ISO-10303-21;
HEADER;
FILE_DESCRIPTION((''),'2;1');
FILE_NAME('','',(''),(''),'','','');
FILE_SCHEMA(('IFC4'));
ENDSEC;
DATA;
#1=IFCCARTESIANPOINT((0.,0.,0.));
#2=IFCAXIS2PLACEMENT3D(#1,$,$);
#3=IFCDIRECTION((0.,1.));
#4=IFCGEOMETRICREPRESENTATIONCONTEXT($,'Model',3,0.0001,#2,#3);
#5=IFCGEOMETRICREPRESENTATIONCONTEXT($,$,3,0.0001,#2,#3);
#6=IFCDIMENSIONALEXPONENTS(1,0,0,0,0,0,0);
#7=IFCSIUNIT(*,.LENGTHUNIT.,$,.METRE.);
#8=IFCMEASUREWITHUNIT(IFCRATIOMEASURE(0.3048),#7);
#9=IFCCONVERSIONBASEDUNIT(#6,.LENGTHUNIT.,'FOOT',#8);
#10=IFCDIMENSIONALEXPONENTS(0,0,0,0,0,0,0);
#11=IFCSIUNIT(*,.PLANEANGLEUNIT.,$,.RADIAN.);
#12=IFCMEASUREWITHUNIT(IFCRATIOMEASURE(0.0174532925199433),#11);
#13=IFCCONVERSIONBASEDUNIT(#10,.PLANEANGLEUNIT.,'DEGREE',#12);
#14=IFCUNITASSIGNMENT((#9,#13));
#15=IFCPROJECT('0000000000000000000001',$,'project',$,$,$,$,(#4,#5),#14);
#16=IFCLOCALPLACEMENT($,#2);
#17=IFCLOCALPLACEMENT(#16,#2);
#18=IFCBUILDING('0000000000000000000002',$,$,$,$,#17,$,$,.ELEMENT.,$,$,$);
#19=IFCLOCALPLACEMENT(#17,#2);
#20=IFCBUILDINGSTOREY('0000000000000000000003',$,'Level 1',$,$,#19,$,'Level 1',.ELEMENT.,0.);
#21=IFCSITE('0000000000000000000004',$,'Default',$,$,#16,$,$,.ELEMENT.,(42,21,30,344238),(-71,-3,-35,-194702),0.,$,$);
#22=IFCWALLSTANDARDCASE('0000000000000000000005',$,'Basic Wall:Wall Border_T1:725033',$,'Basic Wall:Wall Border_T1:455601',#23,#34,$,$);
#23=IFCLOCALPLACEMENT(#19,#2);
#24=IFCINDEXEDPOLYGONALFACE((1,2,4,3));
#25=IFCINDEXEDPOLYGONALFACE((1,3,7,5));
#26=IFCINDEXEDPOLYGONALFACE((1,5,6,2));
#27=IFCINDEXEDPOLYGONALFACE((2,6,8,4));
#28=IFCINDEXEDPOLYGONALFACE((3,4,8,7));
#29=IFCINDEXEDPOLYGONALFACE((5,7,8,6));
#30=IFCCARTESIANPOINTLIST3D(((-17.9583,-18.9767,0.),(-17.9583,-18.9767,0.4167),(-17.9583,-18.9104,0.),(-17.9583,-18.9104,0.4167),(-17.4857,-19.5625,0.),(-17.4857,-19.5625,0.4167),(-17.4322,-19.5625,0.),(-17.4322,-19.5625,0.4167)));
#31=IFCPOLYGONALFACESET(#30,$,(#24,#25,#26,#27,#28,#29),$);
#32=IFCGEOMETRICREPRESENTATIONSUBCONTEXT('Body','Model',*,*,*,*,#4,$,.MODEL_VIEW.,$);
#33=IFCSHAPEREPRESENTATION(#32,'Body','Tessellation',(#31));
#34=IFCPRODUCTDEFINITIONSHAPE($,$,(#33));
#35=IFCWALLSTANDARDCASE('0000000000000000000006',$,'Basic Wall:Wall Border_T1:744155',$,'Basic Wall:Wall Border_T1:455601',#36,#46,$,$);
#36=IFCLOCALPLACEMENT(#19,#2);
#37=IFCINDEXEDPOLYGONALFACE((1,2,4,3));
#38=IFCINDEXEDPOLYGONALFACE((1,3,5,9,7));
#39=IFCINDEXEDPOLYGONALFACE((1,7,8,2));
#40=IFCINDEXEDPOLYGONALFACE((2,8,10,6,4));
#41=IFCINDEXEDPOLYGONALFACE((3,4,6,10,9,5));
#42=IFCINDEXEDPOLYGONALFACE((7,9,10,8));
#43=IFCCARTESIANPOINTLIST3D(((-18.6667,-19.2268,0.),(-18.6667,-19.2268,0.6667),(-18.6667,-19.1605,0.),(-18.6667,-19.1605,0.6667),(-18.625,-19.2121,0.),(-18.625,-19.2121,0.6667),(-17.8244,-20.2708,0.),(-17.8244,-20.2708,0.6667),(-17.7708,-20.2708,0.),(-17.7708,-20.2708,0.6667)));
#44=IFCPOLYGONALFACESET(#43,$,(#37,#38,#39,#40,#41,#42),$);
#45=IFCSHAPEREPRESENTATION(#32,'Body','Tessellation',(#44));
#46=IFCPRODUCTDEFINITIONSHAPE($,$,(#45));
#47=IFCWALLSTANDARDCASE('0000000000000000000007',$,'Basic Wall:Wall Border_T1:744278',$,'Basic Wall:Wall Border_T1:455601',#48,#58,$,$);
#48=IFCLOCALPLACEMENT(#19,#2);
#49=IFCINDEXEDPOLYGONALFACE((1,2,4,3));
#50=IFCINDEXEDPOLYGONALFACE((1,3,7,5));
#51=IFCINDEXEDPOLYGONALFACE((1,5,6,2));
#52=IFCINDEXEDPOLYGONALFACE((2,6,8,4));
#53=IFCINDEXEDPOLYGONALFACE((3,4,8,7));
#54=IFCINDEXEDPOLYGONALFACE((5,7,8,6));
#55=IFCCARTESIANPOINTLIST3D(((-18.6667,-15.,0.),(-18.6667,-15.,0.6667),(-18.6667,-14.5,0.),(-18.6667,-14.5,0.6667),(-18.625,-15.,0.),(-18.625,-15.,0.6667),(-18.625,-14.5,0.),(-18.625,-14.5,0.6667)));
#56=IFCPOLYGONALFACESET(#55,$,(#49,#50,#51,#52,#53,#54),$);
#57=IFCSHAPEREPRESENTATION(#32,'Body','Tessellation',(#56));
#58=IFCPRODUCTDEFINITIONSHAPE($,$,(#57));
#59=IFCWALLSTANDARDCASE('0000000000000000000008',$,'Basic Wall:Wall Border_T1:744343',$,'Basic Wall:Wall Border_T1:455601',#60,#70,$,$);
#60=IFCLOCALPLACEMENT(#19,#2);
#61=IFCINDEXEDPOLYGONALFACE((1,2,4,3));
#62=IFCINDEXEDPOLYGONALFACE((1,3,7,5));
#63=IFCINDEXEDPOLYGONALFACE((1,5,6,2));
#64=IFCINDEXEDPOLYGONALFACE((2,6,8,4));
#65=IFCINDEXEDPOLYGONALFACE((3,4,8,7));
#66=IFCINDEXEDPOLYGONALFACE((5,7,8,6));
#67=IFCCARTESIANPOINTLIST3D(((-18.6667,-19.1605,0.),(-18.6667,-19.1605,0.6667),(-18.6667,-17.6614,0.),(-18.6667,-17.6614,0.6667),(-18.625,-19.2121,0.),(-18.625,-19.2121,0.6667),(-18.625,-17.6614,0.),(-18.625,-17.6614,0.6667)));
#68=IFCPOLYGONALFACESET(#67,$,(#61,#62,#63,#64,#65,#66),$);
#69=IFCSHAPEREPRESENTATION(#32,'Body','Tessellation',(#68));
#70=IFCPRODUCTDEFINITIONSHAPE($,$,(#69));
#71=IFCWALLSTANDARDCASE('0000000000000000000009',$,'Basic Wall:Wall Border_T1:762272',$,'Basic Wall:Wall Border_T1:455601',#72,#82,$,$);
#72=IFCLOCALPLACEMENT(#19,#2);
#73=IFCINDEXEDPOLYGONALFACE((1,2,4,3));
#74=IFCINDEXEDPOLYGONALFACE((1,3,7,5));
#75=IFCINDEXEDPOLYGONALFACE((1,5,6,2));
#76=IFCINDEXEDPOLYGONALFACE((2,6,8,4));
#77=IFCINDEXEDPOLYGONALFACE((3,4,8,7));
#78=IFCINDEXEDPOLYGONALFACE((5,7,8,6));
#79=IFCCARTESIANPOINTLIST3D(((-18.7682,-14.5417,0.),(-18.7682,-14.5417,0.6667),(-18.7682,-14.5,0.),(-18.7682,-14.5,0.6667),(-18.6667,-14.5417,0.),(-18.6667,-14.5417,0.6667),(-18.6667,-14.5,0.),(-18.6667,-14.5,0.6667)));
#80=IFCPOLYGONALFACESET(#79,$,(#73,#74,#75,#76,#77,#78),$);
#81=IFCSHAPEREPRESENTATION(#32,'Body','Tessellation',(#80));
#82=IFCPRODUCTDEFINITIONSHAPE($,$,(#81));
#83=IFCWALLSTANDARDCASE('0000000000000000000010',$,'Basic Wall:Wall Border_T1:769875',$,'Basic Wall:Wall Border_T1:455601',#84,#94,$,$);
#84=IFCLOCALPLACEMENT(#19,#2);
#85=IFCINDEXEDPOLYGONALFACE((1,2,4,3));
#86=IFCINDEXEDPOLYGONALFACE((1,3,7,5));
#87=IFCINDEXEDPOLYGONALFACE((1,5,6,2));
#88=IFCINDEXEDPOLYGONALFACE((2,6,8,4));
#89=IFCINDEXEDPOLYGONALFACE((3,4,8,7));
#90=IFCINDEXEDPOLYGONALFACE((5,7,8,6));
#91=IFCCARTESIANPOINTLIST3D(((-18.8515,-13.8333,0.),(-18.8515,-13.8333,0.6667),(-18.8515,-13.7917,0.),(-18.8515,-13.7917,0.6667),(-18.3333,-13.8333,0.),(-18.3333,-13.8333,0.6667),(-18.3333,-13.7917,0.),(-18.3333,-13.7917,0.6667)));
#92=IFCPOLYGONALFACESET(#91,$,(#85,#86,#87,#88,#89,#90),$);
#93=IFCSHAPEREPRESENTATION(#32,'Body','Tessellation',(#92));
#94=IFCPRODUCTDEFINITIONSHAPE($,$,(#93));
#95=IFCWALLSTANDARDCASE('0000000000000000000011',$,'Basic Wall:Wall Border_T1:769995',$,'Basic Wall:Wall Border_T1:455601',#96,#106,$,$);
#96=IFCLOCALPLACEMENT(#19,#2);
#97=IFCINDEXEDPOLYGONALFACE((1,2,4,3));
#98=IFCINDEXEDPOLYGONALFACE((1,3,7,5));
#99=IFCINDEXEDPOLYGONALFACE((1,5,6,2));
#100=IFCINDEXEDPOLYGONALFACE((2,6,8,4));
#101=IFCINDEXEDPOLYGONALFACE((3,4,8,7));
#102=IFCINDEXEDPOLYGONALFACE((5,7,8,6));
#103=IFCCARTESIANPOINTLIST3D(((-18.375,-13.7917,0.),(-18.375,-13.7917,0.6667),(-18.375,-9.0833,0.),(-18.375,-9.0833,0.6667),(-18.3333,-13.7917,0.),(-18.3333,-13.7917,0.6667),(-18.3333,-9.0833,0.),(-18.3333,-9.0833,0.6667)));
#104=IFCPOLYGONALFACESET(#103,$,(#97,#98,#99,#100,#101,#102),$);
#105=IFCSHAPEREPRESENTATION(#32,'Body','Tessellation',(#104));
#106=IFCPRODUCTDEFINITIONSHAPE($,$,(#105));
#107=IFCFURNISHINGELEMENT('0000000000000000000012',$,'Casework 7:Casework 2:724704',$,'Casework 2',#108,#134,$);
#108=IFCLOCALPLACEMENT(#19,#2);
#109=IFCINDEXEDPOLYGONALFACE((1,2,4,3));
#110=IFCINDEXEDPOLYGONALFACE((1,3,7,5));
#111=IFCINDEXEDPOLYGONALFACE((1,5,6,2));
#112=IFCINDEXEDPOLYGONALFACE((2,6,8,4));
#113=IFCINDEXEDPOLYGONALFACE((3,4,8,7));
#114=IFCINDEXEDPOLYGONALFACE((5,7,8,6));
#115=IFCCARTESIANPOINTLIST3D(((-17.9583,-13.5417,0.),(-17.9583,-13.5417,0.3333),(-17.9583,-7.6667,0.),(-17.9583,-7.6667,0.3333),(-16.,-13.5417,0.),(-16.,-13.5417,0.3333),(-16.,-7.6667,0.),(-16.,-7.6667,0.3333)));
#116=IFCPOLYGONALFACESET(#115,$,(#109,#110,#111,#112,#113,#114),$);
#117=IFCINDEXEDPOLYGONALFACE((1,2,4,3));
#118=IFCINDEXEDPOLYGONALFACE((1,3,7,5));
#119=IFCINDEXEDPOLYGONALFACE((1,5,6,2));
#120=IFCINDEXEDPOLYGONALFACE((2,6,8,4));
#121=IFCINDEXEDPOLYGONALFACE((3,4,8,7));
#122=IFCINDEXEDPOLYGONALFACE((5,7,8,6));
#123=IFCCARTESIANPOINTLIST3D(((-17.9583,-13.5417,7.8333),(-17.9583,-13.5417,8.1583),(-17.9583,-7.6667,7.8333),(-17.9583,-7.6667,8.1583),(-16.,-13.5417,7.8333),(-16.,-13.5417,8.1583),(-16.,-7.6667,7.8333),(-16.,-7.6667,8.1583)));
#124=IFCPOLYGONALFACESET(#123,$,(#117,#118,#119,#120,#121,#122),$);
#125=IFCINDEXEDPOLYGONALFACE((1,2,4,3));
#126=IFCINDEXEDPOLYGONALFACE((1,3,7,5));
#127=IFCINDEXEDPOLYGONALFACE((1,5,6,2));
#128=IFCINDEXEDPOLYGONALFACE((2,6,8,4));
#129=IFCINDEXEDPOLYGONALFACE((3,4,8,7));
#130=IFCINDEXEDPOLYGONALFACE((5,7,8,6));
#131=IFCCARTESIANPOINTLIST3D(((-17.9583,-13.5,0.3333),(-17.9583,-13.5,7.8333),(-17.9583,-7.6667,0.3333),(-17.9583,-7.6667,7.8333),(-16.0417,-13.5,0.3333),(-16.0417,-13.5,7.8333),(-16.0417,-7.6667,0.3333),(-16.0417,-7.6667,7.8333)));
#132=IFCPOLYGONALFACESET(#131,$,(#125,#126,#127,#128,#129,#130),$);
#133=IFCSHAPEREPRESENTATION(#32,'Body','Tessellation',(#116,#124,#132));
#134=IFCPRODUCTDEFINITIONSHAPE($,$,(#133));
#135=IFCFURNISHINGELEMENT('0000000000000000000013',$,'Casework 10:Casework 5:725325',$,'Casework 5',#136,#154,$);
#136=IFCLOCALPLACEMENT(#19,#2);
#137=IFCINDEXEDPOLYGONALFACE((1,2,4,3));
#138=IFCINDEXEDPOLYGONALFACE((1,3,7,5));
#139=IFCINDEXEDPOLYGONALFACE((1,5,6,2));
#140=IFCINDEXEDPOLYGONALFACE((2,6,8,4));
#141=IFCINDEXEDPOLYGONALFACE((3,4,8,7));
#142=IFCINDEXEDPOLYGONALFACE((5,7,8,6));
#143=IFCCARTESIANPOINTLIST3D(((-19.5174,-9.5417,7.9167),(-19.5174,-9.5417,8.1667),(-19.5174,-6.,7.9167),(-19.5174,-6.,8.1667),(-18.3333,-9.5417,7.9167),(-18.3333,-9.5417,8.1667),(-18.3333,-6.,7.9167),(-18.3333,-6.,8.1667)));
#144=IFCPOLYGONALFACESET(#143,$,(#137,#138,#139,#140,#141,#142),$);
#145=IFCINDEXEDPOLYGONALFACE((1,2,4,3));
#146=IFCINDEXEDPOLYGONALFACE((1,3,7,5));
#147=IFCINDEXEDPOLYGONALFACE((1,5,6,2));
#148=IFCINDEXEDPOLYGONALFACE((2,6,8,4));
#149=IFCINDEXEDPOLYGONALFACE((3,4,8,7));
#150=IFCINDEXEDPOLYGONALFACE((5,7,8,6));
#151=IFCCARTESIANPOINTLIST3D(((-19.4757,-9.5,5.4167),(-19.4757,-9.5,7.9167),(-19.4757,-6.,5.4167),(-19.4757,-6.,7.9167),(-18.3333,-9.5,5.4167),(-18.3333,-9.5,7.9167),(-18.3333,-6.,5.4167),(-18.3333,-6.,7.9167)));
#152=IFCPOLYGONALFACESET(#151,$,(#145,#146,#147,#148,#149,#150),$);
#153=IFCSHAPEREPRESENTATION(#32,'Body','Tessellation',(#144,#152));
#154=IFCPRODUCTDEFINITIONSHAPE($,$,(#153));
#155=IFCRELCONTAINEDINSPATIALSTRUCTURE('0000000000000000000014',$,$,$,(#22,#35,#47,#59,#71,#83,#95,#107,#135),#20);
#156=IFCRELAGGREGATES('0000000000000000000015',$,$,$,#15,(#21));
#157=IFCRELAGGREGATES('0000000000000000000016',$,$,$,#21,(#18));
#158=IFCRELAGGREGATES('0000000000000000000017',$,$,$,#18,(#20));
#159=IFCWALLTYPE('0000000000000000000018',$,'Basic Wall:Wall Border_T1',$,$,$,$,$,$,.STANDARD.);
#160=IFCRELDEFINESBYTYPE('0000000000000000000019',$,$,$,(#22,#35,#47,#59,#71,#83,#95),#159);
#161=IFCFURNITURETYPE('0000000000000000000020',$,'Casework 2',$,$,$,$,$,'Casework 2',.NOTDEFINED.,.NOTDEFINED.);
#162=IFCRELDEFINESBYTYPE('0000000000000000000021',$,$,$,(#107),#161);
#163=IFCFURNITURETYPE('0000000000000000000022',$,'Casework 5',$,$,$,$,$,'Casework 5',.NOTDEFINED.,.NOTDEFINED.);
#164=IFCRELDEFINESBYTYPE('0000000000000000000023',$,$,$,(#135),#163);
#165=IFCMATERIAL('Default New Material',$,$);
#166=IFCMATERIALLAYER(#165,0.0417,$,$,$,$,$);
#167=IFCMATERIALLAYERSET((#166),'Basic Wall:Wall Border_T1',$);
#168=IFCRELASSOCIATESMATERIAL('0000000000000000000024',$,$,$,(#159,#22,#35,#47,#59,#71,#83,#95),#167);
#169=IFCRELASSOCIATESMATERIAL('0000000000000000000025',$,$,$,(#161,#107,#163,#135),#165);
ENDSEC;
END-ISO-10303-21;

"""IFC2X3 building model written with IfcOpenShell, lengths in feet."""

from ifc_helpers import new_model, entity, si_unit, converted_unit, direction, frame, frame_2d, origin, place, context, subcontext, project, spatial, polyline, rectangle, outline, extrude, clip, bounded_halfspace, source, transform, mapped, material, layer, layer_set, layer_usage, type_object, type_shapes, element, save


model = new_model("IFC2X3")

# Units and contexts
model_context = context("Model", 3, precision=0.0001, world=origin(), true_north=direction((0.0, 1.0)))
context_of_model = context(None, 3, precision=0.0001, world=origin(), true_north=direction((0.0, 1.0)))
body_context = subcontext(model_context, "Body", "Model", "MODEL_VIEW")
ifc_project = project(units=[converted_unit("LENGTHUNIT", "FOOT", entity("IfcRatioMeasure", 0.3048), si_unit("LENGTHUNIT", "METRE"), dimensions=[1, 0, 0, 0, 0, 0, 0]), converted_unit("PLANEANGLEUNIT", "DEGREE", entity("IfcRatioMeasure", 0.0174532925199433), si_unit("PLANEANGLEUNIT", "RADIAN"), dimensions=[0, 0, 0, 0, 0, 0, 0])], contexts=[model_context, context_of_model])

# Site, building, storey
site_placement = place(None, origin())
site = spatial("IfcSite", under=ifc_project, at=site_placement, Name="Default", CompositionType="ELEMENT", RefLatitude=(42, 21, 30, 344238), RefLongitude=(-71, -3, -35, -194702), RefElevation=0.0)
building_placement = place(site_placement, origin())
building = spatial("IfcBuilding", under=site, at=building_placement, CompositionType="ELEMENT")
storey_placement = place(building_placement, origin())
storey = spatial("IfcBuildingStorey", under=building, at=storey_placement, Name="Level 1", LongName="Level 1", CompositionType="ELEMENT", Elevation=0.0)

# Shared definitions
ifc_material = material(Name="Default New Material")

# Walls
ifc_layer_1 = layer(ifc_material, 0.0417)
ifc_layer_set_1 = layer_set([ifc_layer_1], Name="Basic Wall:Wall Border_T1")
wall_type_1 = type_object("IfcWallType", Name="Basic Wall:Wall Border_T1", PredefinedType="STANDARD", material=ifc_layer_set_1)
ifc_layer_usage_1 = layer_usage(ifc_layer_set_1, "AXIS2", "NEGATIVE", 0.0208)
wall_1_placement = place(storey_placement, frame((-17.4484, -19.5756, 0.0), z_axis=(0.0, 0.0, 1.0), x_axis=(-0.627919, 0.778278, 0.0)))
element("IfcWallStandardCase", 1, at=wall_1_placement, inside=storey, type_object=wall_type_1, material=ifc_layer_usage_1, Name="Basic Wall:Wall Border_T1:725033", ObjectType="Basic Wall:Wall Border_T1:455601", context=body_context, shape_type="Clipping", body=[
    clip(extrude(outline(polyline([(0.7863, 0.0208), (0.0336, 0.0208), (0.0, -0.0208), (0.7716, -0.0208), (0.8379, -0.0208), (0.7863, 0.0208)])), origin(), (0.0, 0.0, 1.0), 0.4167), bounded_halfspace(frame((0.0, -0.0208, 0.0), z_axis=(0.778278, -0.627919, 0.0), x_axis=(0.627919, 0.778278, 0.0)), True, frame((0.0, -0.0208, 0.0), z_axis=(0.778278, -0.627919, 0.0), x_axis=(0.627919, 0.778278, 0.0)), polyline([(0.0, 0.0), (0.0535, 0.0), (0.0535, 0.4167), (0.0, 0.4167), (0.0, 0.0)]))),
])
ifc_layer_usage_2 = layer_usage(ifc_layer_set_1, "AXIS2", "POSITIVE", -0.0208)
wall_2_placement = place(storey_placement, frame((-18.6829, -19.1736, 0.0), z_axis=(0.0, 0.0, 1.0), x_axis=(0.627919, -0.778278, 0.0)))
element("IfcWallStandardCase", 2, at=wall_2_placement, inside=storey, type_object=wall_type_1, material=ifc_layer_usage_2, Name="Basic Wall:Wall Border_T1:744155", ObjectType="Basic Wall:Wall Border_T1:455601", context=body_context, shape_type="SweptSolid", body=[
    extrude(outline(polyline([(1.3931, -0.0208), (1.4267, 0.0208), (0.0664, 0.0208), (0.0, 0.0208), (0.0516, -0.0208), (1.3931, -0.0208)])), origin(), (0.0, 0.0, 1.0), 0.6667),
])
ifc_layer_usage_3 = layer_usage(ifc_layer_set_1, "AXIS2", "POSITIVE", -0.0208)
wall_3_placement = place(storey_placement, frame((-18.6458, -14.5, 0.0), z_axis=(0.0, 0.0, 1.0), x_axis=(0.0, -1.0, 0.0)))
element("IfcWallStandardCase", 3, at=wall_3_placement, inside=storey, type_object=wall_type_1, material=ifc_layer_usage_3, Name="Basic Wall:Wall Border_T1:744278", ObjectType="Basic Wall:Wall Border_T1:455601", context=body_context, shape_type="SweptSolid", body=[
    extrude(rectangle(XDim=0.5, YDim=0.0417, at=frame_2d((0.25, 0.0), x_axis=(-1.0, 0.0))), origin(), (0.0, 0.0, 1.0), 0.6667),
])
ifc_layer_usage_4 = layer_usage(ifc_layer_set_1, "AXIS2", "POSITIVE", -0.0208)
wall_4_placement = place(storey_placement, frame((-18.6458, -17.6614, 0.0), z_axis=(0.0, 0.0, 1.0), x_axis=(0.0, -1.0, 0.0)))
element("IfcWallStandardCase", 4, at=wall_4_placement, inside=storey, type_object=wall_type_1, material=ifc_layer_usage_4, Name="Basic Wall:Wall Border_T1:744343", ObjectType="Basic Wall:Wall Border_T1:455601", context=body_context, shape_type="SweptSolid", body=[
    extrude(outline(polyline([(1.4991, -0.0208), (1.5507, 0.0208), (0.0, 0.0208), (0.0, -0.0208), (1.4991, -0.0208)])), origin(), (0.0, 0.0, 1.0), 0.6667),
])
ifc_layer_usage_5 = layer_usage(ifc_layer_set_1, "AXIS2", "NEGATIVE", 0.0208)
wall_5_placement = place(storey_placement, frame((-18.6667, -14.5208, 0.0), z_axis=(0.0, 0.0, 1.0), x_axis=(-1.0, 0.0, 0.0)))
element("IfcWallStandardCase", 5, at=wall_5_placement, inside=storey, type_object=wall_type_1, material=ifc_layer_usage_5, Name="Basic Wall:Wall Border_T1:762272", ObjectType="Basic Wall:Wall Border_T1:455601", context=body_context, shape_type="SweptSolid", body=[
    extrude(rectangle(XDim=0.1015, YDim=0.0417, at=frame_2d((0.0508, 0.0), x_axis=(-1.0, 0.0))), origin(), (0.0, 0.0, 1.0), 0.6667),
])
ifc_layer_usage_6 = layer_usage(ifc_layer_set_1, "AXIS2", "NEGATIVE", 0.0208)
wall_6_placement = place(storey_placement, frame((-18.8515, -13.8125, 0.0)))
element("IfcWallStandardCase", 6, at=wall_6_placement, inside=storey, type_object=wall_type_1, material=ifc_layer_usage_6, Name="Basic Wall:Wall Border_T1:769875", ObjectType="Basic Wall:Wall Border_T1:455601", context=body_context, shape_type="SweptSolid", body=[
    extrude(rectangle(XDim=0.5182, YDim=0.0417, at=frame_2d((0.2591, 0.0), x_axis=(-1.0, 0.0))), origin(), (0.0, 0.0, 1.0), 0.6667),
])
ifc_layer_usage_7 = layer_usage(ifc_layer_set_1, "AXIS2", "NEGATIVE", 0.0208)
wall_7_placement = place(storey_placement, frame((-18.3542, -13.7917, 0.0), z_axis=(0.0, 0.0, 1.0), x_axis=(0.0, 1.0, 0.0)))
element("IfcWallStandardCase", 7, at=wall_7_placement, inside=storey, type_object=wall_type_1, material=ifc_layer_usage_7, Name="Basic Wall:Wall Border_T1:769995", ObjectType="Basic Wall:Wall Border_T1:455601", context=body_context, shape_type="SweptSolid", body=[
    extrude(rectangle(XDim=4.7083, YDim=0.0417, at=frame_2d((2.3542, 0.0), x_axis=(-1.0, 0.0))), origin(), (0.0, 0.0, 1.0), 0.6667),
])

# Furnishing elements
furniture_type_1 = type_object("IfcFurnitureType", Name="Casework 2", ElementType="Casework 2", AssemblyPlace="NOTDEFINED", material=ifc_material)
shared_shape_1 = source(origin(), body_context, "Body", "SweptSolid", [
    extrude(rectangle(XDim=1.9583, YDim=5.875, at=frame_2d((0.0, 0.0), x_axis=(1.0, 0.0))), frame((0.9792, 2.9375, 0.0)), (0.0, 0.0, 1.0), 0.3333),
    extrude(rectangle(XDim=1.9583, YDim=5.875, at=frame_2d((0.0, 0.0), x_axis=(1.0, 0.0))), frame((0.9792, 2.9375, 7.8333)), (0.0, 0.0, 1.0), 0.3249),
    extrude(rectangle(XDim=1.9167, YDim=5.8333, at=frame_2d((0.0, 0.0), x_axis=(1.0, 0.0))), frame((0.9583, 2.9583, 0.3333), z_axis=(0.0, 0.0, 1.0), x_axis=(-1.0, 0.0, 0.0)), (0.0, 0.0, 1.0), 7.5),
])
type_shapes(furniture_type_1, [shared_shape_1])
furnishing_1_placement = place(storey_placement, frame((-17.9583, -13.5417, 0.0)))
element("IfcFurnishingElement", 8, at=furnishing_1_placement, inside=storey, type_object=furniture_type_1, material=ifc_material, Name="Casework 7:Casework 2:724704", ObjectType="Casework 2", context=body_context, shape_type="MappedRepresentation", body=[
    mapped(shared_shape_1, transform((0.0, 0.0, 0.0), scale=1.0)),
])
furniture_type_2 = type_object("IfcFurnitureType", Name="Casework 5", ElementType="Casework 5", AssemblyPlace="NOTDEFINED", material=ifc_material)
shared_shape_2 = source(origin(), body_context, "Body", "SweptSolid", [
    extrude(rectangle(XDim=3.5417, YDim=1.1841, at=frame_2d((0.0, 0.0), x_axis=(1.0, 0.0))), frame((0.592, 1.7708, 2.5), z_axis=(0.0, 0.0, 1.0), x_axis=(0.0, 1.0, 0.0)), (0.0, 0.0, 1.0), 0.25),
    extrude(rectangle(XDim=1.1424, YDim=3.5, at=frame_2d((0.0, 0.0), x_axis=(1.0, 0.0))), frame((0.6129, 1.7917, 0.0)), (0.0, 0.0, 1.0), 2.5),
])
type_shapes(furniture_type_2, [shared_shape_2])
furnishing_2_placement = place(storey_placement, frame((-19.5174, -9.5417, 5.4167)))
element("IfcFurnishingElement", 9, at=furnishing_2_placement, inside=storey, type_object=furniture_type_2, material=ifc_material, Name="Casework 10:Casework 5:725325", ObjectType="Casework 5", context=body_context, shape_type="MappedRepresentation", body=[
    mapped(shared_shape_2, transform((0.0, 0.0, 0.0), scale=1.0)),
])

save(model, "model.ifc")
